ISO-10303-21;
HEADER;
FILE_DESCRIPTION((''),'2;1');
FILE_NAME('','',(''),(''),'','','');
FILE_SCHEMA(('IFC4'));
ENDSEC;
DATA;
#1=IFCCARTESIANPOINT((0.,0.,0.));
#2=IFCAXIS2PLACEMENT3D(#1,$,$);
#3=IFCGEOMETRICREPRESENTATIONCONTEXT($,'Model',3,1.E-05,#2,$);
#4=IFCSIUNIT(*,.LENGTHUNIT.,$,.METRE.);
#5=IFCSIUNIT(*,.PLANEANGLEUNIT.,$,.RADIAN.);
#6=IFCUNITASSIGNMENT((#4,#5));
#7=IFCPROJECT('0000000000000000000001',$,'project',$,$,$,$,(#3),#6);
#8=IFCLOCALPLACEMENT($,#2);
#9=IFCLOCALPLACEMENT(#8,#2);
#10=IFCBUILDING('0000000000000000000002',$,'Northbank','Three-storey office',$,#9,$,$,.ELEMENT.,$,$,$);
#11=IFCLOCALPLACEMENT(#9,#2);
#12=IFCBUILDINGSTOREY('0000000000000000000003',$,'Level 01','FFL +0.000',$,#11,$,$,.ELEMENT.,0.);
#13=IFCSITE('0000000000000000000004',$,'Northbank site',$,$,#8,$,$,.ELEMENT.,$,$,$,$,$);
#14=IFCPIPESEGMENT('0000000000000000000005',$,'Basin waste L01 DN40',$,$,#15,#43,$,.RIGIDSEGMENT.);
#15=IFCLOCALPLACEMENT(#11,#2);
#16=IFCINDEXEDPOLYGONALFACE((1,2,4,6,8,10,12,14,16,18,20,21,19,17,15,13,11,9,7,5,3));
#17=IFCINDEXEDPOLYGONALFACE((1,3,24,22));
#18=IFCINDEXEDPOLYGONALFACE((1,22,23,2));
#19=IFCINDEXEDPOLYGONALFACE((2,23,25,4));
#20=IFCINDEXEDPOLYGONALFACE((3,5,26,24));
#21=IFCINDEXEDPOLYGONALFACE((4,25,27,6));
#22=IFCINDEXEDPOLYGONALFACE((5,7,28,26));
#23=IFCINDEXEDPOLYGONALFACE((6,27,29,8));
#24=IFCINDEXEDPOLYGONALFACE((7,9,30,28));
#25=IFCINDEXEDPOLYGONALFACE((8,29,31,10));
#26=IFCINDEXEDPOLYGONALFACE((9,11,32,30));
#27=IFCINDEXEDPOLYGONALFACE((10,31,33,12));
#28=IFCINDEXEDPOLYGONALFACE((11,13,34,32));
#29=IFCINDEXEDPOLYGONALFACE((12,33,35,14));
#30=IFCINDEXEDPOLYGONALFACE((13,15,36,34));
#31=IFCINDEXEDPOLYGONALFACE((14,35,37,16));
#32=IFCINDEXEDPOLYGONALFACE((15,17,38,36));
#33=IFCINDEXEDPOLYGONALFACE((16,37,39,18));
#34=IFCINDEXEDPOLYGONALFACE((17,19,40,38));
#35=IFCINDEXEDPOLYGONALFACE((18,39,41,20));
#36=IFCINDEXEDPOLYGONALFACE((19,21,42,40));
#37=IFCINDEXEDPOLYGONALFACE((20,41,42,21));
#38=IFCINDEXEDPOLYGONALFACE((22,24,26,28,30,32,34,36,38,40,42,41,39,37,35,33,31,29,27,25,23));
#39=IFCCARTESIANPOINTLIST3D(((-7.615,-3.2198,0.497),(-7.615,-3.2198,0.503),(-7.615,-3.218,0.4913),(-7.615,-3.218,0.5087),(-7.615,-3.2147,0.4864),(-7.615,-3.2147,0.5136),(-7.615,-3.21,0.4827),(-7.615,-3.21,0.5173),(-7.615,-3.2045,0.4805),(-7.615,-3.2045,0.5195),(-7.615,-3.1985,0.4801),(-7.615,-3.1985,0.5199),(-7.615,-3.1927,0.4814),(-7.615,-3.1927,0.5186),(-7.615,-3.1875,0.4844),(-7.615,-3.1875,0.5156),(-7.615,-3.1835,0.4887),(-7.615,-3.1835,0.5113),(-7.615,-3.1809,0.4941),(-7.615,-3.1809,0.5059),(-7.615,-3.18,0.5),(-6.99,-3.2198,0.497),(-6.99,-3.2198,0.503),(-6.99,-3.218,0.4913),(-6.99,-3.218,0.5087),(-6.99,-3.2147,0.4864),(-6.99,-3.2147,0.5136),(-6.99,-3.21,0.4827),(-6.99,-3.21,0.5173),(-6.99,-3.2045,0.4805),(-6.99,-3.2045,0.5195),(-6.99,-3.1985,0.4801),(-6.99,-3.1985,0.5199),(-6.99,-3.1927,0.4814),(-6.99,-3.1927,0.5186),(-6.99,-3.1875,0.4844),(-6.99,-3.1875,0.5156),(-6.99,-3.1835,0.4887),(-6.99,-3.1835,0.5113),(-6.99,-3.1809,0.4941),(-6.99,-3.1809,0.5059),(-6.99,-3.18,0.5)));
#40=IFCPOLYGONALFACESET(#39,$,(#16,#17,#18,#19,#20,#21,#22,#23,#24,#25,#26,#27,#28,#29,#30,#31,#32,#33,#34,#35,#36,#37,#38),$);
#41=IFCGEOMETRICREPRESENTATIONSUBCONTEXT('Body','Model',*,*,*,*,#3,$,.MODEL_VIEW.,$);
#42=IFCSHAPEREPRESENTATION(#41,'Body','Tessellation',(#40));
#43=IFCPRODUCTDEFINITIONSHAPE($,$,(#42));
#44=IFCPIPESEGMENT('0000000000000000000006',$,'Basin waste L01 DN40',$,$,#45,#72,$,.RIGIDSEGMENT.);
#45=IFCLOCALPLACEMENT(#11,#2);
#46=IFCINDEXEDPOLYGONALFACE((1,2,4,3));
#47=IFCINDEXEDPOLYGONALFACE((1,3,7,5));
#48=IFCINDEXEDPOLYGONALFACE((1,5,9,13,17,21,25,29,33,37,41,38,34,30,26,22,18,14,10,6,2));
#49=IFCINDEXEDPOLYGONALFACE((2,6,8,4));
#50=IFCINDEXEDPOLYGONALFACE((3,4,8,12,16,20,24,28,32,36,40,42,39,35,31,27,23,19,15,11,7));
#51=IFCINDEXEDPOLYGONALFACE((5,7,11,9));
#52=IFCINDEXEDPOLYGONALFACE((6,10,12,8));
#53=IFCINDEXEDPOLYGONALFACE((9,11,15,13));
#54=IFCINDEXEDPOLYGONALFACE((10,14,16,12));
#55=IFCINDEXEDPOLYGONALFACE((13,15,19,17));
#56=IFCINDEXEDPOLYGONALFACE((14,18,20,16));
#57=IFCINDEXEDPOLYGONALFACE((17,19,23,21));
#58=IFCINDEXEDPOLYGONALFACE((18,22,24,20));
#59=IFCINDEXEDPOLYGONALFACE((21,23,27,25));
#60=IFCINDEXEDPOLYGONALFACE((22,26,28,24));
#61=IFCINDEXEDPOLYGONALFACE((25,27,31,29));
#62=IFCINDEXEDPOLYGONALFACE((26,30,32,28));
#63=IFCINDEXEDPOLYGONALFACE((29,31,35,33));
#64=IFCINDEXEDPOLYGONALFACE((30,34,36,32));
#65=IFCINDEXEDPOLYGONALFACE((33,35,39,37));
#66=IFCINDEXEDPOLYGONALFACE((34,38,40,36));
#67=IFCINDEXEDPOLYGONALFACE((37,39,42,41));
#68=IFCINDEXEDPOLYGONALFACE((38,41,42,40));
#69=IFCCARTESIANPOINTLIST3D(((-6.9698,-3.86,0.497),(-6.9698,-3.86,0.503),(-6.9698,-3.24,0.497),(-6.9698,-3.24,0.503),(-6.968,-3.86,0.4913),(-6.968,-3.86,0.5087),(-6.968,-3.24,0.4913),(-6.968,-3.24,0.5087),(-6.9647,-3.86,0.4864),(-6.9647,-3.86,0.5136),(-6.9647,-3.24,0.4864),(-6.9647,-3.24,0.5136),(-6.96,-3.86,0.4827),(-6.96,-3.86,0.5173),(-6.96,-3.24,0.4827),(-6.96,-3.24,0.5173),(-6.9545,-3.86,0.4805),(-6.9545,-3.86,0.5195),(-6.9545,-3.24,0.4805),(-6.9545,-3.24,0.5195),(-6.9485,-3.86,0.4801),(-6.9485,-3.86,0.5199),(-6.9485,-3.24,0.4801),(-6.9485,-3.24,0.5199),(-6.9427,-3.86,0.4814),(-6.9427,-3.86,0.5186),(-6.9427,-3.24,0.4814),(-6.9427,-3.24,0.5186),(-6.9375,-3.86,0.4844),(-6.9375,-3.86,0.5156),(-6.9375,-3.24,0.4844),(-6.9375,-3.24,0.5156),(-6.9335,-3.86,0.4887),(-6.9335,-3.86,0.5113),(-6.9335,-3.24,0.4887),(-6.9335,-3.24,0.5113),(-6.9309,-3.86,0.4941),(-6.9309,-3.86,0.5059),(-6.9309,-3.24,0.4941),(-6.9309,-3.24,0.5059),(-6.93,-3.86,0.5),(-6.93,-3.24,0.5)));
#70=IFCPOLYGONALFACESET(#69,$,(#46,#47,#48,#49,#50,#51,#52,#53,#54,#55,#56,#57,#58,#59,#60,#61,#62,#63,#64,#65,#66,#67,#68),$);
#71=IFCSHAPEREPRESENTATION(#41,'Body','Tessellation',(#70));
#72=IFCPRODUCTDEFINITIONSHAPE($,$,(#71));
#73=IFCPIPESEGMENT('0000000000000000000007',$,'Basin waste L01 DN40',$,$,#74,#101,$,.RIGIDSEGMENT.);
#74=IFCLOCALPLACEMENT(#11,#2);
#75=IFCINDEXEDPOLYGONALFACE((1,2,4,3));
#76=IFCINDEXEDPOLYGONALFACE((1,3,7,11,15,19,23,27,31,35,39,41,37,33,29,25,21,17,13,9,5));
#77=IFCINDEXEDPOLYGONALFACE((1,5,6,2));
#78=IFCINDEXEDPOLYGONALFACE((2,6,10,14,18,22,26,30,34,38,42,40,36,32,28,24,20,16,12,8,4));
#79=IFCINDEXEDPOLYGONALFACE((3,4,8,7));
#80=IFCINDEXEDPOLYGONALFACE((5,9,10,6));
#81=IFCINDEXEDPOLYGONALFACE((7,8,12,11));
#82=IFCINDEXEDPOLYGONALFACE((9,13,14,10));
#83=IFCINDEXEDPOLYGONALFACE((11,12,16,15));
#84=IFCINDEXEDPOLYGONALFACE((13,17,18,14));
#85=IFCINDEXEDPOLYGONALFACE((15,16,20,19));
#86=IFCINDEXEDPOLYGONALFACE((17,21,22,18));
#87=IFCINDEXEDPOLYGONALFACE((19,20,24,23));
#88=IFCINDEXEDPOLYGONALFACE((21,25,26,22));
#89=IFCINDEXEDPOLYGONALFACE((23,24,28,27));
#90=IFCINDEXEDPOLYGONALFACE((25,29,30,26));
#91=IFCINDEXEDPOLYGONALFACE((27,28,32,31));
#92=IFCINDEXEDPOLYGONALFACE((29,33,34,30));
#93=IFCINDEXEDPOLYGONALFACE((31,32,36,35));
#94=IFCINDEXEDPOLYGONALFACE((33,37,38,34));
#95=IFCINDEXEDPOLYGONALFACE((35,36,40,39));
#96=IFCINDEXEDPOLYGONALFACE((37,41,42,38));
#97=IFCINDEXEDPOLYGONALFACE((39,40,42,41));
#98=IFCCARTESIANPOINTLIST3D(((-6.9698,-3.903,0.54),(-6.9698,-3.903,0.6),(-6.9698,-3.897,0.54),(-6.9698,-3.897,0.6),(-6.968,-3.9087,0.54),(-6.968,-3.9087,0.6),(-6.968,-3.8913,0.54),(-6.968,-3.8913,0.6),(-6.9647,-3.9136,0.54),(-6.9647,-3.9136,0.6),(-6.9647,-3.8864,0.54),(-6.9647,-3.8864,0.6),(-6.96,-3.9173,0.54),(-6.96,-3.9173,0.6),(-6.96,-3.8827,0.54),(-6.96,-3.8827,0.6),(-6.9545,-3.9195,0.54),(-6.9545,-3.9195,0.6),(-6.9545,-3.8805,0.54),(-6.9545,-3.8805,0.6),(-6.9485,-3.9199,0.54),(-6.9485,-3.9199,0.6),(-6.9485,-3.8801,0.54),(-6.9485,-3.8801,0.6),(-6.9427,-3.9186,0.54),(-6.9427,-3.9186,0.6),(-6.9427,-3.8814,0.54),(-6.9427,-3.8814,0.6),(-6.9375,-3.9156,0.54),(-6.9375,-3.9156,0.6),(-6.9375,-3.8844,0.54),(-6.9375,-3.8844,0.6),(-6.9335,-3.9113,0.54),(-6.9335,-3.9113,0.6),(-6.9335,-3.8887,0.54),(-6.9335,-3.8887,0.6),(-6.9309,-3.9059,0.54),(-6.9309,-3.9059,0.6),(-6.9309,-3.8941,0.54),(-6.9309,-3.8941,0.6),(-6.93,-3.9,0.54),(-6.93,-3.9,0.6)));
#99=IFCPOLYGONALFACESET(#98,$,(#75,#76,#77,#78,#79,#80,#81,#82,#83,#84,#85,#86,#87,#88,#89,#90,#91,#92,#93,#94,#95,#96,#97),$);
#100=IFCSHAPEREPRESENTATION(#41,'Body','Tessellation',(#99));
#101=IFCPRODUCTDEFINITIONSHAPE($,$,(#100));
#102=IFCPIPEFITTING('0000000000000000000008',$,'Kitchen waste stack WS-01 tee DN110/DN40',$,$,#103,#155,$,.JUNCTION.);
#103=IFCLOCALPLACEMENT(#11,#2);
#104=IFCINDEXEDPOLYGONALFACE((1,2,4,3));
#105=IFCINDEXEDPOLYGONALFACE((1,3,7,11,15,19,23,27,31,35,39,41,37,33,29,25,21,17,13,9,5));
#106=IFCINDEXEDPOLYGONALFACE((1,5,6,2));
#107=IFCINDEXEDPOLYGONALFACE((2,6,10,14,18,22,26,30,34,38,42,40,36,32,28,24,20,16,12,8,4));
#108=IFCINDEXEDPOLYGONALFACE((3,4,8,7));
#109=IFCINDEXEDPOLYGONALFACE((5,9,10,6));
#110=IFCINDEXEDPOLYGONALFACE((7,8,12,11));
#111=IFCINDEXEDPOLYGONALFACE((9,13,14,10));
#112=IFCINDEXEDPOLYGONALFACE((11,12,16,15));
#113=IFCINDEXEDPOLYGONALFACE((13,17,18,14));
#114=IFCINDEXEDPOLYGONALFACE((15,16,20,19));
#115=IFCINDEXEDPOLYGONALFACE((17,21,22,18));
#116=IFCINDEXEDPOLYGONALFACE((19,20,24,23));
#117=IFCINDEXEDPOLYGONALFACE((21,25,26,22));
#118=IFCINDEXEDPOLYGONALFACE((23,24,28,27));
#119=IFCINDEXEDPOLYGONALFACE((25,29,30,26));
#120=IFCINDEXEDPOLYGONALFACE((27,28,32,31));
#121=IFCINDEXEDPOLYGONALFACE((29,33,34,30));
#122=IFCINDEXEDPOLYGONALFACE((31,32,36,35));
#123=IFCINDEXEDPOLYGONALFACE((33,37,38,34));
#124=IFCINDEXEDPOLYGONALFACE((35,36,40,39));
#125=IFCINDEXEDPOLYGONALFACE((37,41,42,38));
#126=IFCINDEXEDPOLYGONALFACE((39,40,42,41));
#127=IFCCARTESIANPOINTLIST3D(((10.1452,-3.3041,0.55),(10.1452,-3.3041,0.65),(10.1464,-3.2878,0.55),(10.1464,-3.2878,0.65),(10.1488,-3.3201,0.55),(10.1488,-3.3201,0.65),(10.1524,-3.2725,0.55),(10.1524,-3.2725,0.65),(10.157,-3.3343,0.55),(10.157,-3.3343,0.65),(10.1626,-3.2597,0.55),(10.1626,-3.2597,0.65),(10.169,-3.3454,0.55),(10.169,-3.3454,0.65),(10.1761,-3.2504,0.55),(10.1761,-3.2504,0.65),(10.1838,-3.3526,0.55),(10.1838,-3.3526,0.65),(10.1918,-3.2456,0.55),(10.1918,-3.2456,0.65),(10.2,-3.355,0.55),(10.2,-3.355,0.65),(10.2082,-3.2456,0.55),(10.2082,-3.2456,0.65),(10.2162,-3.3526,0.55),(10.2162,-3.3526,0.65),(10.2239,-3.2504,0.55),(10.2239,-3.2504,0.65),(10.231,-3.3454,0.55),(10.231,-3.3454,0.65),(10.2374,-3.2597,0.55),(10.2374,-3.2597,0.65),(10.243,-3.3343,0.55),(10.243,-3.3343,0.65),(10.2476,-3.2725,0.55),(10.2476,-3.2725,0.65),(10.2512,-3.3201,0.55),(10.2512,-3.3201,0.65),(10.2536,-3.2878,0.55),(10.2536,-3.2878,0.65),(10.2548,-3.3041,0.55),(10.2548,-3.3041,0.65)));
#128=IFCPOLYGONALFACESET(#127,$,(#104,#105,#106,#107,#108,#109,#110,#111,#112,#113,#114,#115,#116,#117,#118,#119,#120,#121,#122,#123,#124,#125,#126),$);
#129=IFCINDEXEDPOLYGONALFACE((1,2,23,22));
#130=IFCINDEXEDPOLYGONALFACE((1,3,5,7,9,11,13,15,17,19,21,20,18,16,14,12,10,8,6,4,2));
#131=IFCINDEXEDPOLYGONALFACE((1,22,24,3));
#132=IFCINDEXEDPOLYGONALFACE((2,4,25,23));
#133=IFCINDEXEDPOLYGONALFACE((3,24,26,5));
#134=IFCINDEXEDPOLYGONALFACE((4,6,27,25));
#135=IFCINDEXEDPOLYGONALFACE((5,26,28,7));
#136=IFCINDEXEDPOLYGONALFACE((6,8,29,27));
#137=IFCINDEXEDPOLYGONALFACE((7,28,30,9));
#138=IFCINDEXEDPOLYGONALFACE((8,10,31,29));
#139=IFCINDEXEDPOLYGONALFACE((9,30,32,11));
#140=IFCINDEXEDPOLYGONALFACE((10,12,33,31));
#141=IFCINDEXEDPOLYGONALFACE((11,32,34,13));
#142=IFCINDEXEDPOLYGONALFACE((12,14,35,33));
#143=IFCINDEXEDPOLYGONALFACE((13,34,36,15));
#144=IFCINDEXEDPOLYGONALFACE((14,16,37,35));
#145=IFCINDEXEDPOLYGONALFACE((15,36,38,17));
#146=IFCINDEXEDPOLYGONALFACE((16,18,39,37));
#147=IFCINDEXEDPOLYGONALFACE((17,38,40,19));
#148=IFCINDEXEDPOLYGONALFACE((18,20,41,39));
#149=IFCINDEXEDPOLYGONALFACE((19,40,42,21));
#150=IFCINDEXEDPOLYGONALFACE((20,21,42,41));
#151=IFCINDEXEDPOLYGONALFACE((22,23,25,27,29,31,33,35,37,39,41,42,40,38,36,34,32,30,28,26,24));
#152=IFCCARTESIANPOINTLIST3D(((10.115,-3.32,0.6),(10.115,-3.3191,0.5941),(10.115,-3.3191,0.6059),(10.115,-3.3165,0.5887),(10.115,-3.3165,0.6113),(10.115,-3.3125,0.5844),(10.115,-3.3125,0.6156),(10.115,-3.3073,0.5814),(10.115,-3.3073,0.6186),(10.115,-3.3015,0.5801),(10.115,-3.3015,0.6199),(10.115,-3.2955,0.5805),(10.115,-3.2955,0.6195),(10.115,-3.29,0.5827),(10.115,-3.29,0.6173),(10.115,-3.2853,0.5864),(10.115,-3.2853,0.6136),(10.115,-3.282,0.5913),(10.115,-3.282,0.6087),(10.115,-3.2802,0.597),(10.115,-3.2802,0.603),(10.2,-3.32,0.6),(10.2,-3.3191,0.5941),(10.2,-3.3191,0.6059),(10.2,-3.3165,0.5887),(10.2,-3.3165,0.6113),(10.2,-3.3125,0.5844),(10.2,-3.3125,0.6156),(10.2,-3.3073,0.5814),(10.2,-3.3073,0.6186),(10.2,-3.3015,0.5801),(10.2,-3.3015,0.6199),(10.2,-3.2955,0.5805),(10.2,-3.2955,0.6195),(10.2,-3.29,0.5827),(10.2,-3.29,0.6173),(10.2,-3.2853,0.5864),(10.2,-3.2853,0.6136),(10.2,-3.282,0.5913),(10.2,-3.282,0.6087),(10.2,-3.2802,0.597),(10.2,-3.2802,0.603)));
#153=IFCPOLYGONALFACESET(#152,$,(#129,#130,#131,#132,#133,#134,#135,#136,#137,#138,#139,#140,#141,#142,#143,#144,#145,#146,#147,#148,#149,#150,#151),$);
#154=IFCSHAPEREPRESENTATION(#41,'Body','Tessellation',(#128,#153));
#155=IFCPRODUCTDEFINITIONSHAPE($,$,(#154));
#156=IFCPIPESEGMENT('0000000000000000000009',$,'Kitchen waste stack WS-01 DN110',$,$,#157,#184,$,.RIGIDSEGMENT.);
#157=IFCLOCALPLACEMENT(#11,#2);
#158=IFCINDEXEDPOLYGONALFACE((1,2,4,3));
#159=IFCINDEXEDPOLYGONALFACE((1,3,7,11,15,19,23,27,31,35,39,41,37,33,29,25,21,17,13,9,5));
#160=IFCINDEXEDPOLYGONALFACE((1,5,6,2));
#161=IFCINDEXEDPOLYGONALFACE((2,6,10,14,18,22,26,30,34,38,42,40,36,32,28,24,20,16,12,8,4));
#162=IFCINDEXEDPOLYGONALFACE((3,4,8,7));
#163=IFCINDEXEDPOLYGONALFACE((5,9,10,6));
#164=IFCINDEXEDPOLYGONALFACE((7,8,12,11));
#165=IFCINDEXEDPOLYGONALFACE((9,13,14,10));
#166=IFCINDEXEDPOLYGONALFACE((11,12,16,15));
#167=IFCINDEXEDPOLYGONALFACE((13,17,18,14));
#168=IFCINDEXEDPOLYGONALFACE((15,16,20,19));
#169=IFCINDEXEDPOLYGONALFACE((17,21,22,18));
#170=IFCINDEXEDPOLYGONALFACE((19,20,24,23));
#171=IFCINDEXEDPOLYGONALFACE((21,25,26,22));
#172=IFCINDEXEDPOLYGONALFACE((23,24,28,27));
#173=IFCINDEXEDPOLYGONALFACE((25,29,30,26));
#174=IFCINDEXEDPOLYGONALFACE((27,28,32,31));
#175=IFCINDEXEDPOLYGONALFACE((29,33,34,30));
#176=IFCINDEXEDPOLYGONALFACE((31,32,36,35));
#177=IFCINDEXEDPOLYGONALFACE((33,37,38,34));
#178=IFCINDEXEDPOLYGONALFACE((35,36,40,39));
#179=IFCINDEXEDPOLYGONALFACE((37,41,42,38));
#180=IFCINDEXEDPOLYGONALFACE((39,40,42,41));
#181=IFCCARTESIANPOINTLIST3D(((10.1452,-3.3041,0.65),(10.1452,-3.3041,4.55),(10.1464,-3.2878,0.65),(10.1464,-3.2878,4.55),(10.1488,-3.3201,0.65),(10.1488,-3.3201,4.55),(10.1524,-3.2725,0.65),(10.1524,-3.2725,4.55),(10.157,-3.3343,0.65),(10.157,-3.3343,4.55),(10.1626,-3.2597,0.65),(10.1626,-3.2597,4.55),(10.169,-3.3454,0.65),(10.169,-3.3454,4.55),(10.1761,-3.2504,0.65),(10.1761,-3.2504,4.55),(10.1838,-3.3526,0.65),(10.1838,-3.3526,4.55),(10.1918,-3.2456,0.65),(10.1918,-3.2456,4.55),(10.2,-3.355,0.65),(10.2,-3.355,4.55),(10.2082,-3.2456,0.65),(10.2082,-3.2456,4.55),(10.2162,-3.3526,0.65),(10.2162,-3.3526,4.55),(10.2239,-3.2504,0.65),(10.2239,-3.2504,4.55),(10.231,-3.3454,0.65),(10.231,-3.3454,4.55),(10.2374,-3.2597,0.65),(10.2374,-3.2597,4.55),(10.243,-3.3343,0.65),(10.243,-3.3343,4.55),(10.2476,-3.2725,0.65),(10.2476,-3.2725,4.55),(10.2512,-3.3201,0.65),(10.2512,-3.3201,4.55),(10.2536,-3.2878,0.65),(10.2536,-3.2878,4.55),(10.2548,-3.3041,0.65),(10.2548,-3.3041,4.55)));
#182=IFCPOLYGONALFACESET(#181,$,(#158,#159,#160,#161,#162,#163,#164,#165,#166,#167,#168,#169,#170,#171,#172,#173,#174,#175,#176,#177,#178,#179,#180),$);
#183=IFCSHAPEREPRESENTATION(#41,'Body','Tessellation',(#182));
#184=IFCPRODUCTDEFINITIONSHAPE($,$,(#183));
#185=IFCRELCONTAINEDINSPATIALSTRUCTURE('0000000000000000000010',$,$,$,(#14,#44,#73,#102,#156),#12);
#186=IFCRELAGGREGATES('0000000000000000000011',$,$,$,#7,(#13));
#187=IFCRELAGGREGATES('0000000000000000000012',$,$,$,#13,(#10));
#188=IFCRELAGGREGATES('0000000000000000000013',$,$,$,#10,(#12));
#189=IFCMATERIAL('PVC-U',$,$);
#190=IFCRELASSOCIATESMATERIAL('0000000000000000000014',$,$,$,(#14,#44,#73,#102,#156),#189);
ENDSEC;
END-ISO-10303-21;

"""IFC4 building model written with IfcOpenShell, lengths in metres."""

from ifc_helpers import new_model, si_unit, frame, origin, place, context, subcontext, project, spatial, circle, extrude, material, element, save


model = new_model("IFC4")

# Units and contexts
model_context = context("Model", 3, precision=1e-05, world=origin())
body_context = subcontext(model_context, "Body", "Model", "MODEL_VIEW")
ifc_project = project(units=[si_unit("LENGTHUNIT", "METRE"), si_unit("PLANEANGLEUNIT", "RADIAN")], contexts=[model_context])

# Site, building, storey
site_placement = place(None, origin())
site = spatial("IfcSite", under=ifc_project, at=site_placement, Name="Northbank site", CompositionType="ELEMENT")
building_placement = place(site_placement, origin())
building = spatial("IfcBuilding", under=site, at=building_placement, Name="Northbank", Description="Three-storey office", CompositionType="ELEMENT")
storey_placement = place(building_placement, origin())
storey = spatial("IfcBuildingStorey", under=building, at=storey_placement, Name="Level 01", Description="FFL +0.000", CompositionType="ELEMENT", Elevation=0.0)

# Shared definitions
ifc_material_1 = material(Name="PVC-U")

# Pipe segments
pipe_segment_1_placement = place(storey_placement, origin())
element("IfcPipeSegment", 1, at=pipe_segment_1_placement, inside=storey, material=ifc_material_1, Name="Basin waste L01 DN40", PredefinedType="RIGIDSEGMENT", context=body_context, shape_type="SweptSolid", body=[
    extrude(circle(Radius=0.02), frame((-7.615, -3.2, 0.5), z_axis=(1.0, 0.0, 0.0), x_axis=(0.0, 1.0, 0.0)), (0.0, 0.0, 1.0), 0.625),
])
pipe_segment_2_placement = place(storey_placement, origin())
element("IfcPipeSegment", 2, at=pipe_segment_2_placement, inside=storey, material=ifc_material_1, Name="Basin waste L01 DN40", PredefinedType="RIGIDSEGMENT", context=body_context, shape_type="SweptSolid", body=[
    extrude(circle(Radius=0.02), frame((-6.95, -3.24, 0.5), z_axis=(0.0, -1.0, 0.0), x_axis=(1.0, 0.0, 0.0)), (0.0, 0.0, 1.0), 0.62),
])
pipe_segment_3_placement = place(storey_placement, origin())
element("IfcPipeSegment", 3, at=pipe_segment_3_placement, inside=storey, material=ifc_material_1, Name="Basin waste L01 DN40", PredefinedType="RIGIDSEGMENT", context=body_context, shape_type="SweptSolid", body=[
    extrude(circle(Radius=0.02), frame((-6.95, -3.9, 0.54), z_axis=(0.0, 0.0, 1.0), x_axis=(1.0, 0.0, 0.0)), (0.0, 0.0, 1.0), 0.06),
])

# Pipe fitting
pipe_fitting_1_placement = place(storey_placement, origin())
element("IfcPipeFitting", 4, at=pipe_fitting_1_placement, inside=storey, material=ifc_material_1, Name="Kitchen waste stack WS-01 tee DN110/DN40", PredefinedType="JUNCTION", context=body_context, shape_type="SweptSolid", body=[
    extrude(circle(Radius=0.055), frame((10.2, -3.3, 0.55), z_axis=(0.0, 0.0, 1.0), x_axis=(0.0, -1.0, 0.0)), (0.0, 0.0, 1.0), 0.1),
    extrude(circle(Radius=0.02), frame((10.2, -3.3, 0.6), z_axis=(-1.0, 0.0, 0.0), x_axis=(0.0, -1.0, 0.0)), (0.0, 0.0, 1.0), 0.085),
])

# Pipe segment
pipe_segment_4_placement = place(storey_placement, origin())
element("IfcPipeSegment", 5, at=pipe_segment_4_placement, inside=storey, material=ifc_material_1, Name="Kitchen waste stack WS-01 DN110", PredefinedType="RIGIDSEGMENT", context=body_context, shape_type="SweptSolid", body=[
    extrude(circle(Radius=0.055), frame((10.2, -3.3, 0.65), z_axis=(0.0, 0.0, 1.0), x_axis=(0.0, -1.0, 0.0)), (0.0, 0.0, 1.0), 3.9),
])

save(model, "model.ifc")
